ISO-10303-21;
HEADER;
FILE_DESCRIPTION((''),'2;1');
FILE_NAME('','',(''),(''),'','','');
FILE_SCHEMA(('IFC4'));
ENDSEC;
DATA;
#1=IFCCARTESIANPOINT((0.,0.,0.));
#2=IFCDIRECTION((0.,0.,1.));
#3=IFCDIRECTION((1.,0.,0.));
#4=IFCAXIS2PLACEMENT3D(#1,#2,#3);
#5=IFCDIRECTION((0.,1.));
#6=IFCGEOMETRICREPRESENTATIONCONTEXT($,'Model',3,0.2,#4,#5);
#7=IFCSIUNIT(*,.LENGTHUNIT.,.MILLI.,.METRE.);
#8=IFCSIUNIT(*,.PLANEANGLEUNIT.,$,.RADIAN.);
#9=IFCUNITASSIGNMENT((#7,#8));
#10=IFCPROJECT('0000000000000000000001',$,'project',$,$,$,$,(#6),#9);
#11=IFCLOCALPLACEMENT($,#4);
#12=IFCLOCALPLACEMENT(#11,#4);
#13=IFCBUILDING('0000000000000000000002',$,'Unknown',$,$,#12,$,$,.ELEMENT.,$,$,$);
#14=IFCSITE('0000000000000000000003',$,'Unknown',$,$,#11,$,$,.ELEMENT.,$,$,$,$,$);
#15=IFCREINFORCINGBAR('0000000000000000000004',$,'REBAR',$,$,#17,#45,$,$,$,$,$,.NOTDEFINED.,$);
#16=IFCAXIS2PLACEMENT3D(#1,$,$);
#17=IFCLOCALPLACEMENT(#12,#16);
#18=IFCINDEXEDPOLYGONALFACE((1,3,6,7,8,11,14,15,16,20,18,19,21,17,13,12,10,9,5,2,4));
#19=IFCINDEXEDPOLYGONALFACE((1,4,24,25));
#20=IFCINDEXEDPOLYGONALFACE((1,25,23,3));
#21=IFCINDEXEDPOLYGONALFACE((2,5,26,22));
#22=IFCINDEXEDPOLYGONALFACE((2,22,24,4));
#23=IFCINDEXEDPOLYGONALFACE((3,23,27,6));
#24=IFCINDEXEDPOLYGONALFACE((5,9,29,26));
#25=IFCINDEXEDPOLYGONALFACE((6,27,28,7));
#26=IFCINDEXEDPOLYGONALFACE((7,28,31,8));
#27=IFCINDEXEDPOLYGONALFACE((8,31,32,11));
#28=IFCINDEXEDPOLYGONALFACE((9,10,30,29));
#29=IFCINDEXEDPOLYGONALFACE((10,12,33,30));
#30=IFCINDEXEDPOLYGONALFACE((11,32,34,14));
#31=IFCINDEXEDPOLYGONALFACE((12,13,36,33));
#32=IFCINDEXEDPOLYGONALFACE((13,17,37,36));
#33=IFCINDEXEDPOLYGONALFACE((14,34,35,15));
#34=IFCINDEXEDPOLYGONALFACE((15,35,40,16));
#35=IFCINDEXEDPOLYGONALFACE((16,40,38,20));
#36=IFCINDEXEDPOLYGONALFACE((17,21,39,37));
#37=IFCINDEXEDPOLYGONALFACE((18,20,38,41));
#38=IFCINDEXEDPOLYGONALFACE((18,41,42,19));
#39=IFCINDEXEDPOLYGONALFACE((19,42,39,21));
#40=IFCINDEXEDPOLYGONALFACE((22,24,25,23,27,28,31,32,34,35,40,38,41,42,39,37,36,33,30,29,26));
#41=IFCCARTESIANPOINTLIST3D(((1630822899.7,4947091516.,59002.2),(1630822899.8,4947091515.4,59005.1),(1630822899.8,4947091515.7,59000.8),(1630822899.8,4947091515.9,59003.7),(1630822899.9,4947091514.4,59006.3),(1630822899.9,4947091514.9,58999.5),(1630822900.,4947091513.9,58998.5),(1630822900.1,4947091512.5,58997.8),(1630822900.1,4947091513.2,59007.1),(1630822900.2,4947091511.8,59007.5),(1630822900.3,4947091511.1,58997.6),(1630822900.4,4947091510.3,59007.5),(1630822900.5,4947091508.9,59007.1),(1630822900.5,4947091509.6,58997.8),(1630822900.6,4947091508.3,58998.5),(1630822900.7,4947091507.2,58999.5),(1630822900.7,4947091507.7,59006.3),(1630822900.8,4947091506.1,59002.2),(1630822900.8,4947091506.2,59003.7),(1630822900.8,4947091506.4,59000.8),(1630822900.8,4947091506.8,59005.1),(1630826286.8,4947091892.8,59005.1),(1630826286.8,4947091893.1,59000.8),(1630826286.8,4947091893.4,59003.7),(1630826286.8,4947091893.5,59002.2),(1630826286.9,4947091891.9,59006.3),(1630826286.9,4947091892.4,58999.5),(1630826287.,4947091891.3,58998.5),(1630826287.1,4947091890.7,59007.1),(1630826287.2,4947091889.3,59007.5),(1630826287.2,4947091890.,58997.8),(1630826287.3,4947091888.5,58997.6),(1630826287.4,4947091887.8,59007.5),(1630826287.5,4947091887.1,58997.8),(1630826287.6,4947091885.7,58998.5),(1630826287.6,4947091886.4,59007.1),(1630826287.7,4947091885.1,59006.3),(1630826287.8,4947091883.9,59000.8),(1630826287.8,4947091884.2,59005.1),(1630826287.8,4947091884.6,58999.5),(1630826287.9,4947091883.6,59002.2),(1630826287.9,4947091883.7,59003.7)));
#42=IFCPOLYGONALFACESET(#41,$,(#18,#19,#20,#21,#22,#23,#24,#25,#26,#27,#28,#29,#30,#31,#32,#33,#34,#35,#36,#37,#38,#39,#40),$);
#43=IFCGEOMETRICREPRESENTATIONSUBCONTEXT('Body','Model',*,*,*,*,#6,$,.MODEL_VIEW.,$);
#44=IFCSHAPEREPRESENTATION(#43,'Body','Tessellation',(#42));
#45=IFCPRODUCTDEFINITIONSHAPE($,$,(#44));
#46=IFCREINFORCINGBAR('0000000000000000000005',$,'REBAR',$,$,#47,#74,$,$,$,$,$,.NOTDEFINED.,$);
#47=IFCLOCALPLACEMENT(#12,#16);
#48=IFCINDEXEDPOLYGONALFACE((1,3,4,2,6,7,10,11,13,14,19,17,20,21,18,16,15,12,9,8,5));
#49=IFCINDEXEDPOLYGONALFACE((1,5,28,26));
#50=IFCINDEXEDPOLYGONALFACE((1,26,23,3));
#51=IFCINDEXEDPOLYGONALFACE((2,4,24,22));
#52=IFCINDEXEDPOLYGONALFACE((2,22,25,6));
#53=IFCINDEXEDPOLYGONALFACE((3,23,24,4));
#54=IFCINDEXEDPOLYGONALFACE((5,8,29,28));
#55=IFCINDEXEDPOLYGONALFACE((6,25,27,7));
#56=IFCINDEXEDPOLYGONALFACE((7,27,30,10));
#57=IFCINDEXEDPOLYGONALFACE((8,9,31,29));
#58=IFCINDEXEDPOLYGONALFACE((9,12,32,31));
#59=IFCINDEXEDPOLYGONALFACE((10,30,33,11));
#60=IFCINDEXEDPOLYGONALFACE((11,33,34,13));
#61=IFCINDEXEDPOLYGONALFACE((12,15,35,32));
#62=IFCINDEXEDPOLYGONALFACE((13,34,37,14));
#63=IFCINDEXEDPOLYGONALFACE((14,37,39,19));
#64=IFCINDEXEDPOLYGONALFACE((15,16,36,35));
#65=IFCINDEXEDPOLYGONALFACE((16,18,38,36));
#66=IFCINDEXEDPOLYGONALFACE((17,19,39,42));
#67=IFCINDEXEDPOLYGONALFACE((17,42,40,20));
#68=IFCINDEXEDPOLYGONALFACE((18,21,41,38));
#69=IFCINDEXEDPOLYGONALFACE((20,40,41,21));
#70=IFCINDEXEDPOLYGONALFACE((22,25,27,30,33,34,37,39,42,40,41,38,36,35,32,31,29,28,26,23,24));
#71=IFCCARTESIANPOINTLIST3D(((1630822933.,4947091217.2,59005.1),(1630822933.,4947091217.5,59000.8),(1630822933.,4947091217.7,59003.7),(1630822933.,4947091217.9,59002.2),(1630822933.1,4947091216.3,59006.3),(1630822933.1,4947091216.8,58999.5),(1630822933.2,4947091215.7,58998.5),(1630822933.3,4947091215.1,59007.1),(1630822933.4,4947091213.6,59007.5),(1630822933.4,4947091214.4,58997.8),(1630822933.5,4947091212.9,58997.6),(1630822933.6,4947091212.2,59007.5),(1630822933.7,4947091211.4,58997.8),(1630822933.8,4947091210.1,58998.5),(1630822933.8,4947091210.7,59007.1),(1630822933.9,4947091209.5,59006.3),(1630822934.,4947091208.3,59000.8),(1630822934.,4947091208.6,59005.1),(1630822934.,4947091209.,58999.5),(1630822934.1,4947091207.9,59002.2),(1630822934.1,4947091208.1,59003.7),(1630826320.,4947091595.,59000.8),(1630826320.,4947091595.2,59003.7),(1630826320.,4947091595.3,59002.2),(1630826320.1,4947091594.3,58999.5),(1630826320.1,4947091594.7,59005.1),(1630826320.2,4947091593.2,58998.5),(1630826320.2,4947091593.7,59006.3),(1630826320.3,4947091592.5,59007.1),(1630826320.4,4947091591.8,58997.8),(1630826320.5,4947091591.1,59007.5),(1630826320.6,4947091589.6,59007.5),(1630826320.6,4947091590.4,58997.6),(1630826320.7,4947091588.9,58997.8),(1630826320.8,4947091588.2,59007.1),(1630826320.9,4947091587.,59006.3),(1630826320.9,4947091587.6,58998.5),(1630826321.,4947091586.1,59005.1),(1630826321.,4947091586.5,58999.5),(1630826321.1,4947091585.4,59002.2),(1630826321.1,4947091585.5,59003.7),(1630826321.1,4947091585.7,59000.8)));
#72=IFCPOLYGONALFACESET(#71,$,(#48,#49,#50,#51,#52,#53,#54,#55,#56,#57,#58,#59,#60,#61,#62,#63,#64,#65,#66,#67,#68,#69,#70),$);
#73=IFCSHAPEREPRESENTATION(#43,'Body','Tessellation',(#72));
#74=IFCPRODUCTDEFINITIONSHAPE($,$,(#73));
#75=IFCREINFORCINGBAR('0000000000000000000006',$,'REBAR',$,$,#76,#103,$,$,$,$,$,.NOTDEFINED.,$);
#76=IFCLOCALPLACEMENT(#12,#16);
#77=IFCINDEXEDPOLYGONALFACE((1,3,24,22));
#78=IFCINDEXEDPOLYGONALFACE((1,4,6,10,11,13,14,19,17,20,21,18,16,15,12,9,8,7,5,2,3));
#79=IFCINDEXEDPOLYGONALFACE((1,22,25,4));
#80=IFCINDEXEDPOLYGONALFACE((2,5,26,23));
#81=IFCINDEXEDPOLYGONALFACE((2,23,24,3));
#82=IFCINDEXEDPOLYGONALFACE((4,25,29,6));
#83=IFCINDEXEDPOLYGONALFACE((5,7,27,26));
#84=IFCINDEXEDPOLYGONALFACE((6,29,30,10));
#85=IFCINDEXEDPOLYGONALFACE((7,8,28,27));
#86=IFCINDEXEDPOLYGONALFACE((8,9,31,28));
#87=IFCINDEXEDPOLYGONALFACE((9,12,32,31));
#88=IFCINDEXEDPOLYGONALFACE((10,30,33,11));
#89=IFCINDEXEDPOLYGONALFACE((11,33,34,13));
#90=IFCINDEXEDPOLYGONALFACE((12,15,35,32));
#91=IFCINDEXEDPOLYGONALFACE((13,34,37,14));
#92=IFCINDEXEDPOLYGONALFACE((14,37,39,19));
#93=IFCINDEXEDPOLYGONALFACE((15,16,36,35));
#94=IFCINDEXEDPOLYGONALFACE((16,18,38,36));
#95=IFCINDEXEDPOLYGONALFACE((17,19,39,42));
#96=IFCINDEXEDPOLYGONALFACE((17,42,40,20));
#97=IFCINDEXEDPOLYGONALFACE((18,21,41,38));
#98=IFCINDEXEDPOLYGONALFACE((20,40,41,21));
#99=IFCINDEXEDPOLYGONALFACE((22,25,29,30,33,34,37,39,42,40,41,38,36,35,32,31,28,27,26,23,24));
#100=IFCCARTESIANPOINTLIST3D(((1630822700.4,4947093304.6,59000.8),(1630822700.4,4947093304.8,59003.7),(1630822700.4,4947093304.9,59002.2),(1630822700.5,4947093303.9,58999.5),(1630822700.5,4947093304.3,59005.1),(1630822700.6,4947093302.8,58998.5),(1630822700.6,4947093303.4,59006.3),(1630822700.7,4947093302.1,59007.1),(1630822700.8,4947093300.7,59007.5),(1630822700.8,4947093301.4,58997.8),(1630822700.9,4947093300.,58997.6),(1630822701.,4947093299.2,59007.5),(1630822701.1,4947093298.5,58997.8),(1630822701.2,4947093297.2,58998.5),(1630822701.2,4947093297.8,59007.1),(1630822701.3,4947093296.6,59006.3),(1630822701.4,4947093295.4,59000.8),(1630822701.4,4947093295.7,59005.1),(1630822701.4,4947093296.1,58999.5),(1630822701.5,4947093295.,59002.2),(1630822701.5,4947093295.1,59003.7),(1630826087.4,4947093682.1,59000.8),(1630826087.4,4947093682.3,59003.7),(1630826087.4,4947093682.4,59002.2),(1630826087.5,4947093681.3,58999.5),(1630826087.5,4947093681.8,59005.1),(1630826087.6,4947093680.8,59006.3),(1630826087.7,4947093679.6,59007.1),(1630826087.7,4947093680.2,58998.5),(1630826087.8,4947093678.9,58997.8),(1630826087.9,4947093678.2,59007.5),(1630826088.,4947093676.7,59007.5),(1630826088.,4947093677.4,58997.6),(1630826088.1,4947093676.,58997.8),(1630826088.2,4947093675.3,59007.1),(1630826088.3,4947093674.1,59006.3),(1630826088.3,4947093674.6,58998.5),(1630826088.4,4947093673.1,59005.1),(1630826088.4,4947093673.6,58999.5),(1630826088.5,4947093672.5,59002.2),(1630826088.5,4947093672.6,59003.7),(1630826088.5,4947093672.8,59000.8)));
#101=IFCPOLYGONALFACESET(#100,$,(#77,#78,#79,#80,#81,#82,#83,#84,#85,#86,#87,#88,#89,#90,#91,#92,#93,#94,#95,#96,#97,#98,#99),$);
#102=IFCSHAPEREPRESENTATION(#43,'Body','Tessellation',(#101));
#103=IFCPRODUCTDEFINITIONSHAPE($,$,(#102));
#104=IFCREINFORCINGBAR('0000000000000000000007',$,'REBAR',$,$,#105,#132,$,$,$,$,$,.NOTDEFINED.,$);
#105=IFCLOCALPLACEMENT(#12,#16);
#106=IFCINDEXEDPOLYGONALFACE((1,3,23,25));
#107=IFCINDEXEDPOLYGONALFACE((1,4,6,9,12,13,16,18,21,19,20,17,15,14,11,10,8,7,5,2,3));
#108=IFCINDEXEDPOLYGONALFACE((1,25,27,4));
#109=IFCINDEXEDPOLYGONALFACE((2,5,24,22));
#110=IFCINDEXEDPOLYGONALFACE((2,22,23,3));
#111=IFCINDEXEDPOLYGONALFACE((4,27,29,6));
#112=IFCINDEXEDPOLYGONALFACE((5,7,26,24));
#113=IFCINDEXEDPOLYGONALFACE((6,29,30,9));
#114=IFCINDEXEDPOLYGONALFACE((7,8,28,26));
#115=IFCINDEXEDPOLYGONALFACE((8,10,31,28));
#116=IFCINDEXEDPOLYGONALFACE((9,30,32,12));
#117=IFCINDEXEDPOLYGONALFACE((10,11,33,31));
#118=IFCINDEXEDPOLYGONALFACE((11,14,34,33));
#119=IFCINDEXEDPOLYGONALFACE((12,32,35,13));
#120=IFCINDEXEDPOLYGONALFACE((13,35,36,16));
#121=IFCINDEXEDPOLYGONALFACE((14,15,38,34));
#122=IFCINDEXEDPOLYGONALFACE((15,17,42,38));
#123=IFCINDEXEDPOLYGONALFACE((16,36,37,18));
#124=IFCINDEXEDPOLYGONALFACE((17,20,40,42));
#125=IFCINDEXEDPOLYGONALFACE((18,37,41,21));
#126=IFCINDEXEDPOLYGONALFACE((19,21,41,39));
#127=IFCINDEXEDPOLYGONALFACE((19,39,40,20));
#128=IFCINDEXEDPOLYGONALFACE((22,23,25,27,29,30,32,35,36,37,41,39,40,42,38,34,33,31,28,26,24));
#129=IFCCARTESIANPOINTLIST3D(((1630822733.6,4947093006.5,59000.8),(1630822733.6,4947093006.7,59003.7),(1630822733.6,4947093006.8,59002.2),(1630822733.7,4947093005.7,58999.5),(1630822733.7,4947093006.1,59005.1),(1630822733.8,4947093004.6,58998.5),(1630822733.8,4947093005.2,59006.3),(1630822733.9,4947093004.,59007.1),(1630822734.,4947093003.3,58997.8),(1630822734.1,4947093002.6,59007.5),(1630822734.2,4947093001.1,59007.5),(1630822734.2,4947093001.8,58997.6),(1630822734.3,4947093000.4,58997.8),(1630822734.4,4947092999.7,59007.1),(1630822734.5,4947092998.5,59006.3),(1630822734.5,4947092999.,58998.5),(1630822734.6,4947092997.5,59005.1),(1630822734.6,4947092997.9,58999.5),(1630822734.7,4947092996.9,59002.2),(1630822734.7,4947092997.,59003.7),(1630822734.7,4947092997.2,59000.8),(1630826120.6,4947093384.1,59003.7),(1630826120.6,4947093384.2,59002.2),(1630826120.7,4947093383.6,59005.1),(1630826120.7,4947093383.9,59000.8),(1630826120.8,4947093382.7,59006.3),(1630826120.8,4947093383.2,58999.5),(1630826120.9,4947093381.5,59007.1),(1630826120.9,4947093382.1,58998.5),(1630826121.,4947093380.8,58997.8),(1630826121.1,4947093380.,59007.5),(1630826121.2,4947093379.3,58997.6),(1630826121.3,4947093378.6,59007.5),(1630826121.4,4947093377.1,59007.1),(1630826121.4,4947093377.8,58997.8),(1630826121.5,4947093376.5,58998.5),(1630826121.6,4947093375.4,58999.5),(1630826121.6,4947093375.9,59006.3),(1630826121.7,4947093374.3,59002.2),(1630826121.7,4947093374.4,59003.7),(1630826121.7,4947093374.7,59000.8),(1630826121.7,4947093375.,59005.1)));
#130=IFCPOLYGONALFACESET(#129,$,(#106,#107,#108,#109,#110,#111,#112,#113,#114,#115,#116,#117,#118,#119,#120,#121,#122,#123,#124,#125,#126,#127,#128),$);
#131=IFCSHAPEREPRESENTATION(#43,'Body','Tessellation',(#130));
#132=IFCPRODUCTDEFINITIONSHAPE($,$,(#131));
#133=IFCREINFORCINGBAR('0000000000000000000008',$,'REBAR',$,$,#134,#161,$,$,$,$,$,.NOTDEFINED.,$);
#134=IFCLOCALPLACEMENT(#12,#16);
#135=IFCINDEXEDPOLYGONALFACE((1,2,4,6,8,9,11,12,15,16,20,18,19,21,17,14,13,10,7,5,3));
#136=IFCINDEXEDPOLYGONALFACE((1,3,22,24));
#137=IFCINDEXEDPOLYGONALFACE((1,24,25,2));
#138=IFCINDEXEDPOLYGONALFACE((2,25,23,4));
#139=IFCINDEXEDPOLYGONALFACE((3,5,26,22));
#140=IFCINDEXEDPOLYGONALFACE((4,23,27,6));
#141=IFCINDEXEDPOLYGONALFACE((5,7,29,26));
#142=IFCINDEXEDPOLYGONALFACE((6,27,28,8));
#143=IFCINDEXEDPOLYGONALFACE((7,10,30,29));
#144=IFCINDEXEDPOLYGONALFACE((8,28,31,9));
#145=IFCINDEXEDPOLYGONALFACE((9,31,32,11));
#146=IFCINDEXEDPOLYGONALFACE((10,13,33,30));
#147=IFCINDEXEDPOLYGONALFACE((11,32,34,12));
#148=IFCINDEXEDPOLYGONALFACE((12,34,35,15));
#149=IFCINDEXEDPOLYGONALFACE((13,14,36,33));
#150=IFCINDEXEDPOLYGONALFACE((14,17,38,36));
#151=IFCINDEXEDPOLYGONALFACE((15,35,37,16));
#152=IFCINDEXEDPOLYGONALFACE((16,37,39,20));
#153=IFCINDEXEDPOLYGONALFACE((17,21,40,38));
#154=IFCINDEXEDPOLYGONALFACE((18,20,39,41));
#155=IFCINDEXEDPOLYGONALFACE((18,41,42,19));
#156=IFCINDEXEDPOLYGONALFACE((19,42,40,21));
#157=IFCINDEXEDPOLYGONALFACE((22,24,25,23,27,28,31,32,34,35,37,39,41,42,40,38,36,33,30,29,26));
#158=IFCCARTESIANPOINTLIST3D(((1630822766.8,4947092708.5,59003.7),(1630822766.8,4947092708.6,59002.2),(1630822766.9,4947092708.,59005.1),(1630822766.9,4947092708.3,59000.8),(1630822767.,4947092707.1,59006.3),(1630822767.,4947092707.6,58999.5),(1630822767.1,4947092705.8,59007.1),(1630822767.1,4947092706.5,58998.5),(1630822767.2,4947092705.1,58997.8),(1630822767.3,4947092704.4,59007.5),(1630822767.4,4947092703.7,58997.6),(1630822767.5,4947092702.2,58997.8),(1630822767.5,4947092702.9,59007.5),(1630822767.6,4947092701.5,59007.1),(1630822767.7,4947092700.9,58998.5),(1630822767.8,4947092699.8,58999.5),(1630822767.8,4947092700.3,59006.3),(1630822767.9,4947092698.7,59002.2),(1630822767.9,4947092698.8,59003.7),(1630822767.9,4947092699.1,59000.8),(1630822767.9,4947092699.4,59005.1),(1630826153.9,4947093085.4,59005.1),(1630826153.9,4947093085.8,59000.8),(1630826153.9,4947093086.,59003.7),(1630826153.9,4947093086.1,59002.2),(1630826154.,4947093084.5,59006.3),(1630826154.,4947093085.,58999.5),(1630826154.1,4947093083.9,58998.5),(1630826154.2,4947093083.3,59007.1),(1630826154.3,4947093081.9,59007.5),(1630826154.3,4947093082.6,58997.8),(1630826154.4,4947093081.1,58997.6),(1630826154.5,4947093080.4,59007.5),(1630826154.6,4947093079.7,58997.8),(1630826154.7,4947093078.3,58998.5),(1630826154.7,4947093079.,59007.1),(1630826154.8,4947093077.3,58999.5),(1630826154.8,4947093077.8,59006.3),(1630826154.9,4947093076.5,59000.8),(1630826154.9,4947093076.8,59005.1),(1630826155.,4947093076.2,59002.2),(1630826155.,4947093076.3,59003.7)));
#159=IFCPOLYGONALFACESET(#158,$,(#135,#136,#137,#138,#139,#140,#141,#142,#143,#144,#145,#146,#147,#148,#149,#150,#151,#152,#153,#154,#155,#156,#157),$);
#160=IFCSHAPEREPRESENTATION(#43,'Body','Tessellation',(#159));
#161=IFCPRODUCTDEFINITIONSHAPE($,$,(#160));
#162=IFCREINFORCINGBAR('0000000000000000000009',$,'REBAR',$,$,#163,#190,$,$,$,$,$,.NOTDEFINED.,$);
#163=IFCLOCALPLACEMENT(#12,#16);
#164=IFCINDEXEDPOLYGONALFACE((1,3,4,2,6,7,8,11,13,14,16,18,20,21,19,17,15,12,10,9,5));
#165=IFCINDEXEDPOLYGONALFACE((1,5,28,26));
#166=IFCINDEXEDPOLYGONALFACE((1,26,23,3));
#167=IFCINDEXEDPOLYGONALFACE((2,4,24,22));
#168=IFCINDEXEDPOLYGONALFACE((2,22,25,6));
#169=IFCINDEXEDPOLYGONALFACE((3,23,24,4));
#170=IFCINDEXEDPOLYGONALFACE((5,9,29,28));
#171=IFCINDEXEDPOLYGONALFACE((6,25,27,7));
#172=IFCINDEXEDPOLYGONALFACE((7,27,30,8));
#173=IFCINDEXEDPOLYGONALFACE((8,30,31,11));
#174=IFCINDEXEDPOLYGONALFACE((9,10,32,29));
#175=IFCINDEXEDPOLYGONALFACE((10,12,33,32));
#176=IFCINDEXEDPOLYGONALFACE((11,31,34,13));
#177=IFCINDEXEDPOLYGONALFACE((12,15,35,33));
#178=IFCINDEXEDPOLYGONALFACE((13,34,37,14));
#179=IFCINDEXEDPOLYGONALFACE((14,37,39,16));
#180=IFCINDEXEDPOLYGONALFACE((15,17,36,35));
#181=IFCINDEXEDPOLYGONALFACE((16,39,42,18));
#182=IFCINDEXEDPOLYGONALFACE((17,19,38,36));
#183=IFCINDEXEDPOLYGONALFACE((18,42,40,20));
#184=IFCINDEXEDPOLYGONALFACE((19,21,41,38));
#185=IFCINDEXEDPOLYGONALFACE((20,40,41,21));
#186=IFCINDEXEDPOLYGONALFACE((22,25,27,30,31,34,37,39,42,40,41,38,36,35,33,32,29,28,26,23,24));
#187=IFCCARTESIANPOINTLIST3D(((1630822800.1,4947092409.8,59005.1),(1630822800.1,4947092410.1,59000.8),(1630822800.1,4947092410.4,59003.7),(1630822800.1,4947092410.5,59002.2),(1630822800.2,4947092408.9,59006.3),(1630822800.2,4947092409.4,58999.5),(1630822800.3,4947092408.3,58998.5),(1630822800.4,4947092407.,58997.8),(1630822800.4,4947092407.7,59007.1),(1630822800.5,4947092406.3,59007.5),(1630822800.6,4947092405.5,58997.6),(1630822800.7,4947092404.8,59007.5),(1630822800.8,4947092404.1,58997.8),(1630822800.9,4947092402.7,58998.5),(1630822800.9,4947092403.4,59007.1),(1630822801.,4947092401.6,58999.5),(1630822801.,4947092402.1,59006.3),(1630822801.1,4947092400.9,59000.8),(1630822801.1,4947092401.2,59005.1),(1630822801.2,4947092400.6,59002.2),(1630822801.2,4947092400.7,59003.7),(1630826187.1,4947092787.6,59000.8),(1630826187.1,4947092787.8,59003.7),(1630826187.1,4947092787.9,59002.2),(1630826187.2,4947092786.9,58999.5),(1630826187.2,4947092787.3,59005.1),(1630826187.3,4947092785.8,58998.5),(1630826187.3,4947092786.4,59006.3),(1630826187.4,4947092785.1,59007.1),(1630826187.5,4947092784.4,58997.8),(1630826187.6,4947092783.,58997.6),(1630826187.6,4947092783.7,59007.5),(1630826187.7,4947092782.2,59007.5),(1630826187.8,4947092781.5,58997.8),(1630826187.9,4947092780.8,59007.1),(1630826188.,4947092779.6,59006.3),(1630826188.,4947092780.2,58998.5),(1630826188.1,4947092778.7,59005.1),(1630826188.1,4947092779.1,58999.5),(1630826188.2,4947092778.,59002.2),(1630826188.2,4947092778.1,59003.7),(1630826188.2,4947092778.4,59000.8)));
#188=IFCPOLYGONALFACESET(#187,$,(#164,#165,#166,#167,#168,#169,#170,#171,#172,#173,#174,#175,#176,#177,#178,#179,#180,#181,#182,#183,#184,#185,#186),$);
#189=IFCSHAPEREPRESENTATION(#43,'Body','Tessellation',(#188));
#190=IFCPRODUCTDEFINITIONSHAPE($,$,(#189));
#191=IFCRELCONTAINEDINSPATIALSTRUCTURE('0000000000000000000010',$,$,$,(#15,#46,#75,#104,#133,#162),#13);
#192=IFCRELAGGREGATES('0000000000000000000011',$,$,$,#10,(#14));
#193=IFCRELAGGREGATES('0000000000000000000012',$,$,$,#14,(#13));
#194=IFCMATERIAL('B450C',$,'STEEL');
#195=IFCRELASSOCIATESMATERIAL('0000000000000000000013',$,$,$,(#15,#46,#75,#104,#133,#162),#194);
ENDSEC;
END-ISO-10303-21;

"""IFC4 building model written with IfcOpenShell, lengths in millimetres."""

from ifc_helpers import new_model, entity, si_unit, direction, frame, origin_with_axes, place, context, subcontext, project, spatial, material, element, save


model = new_model("IFC4")

# Units and contexts
model_context = context("Model", 3, precision=0.2, world=origin_with_axes(), true_north=direction((0.0, 1.0)))
body_context = subcontext(model_context, "Body", "Model", "MODEL_VIEW")
ifc_project = project(units=[si_unit("LENGTHUNIT", "METRE", prefix="MILLI"), si_unit("PLANEANGLEUNIT", "RADIAN")], contexts=[model_context])

# Site, building
site_placement = place(None, origin_with_axes())
site = spatial("IfcSite", under=ifc_project, at=site_placement, Name="Unknown", CompositionType="ELEMENT")
building_placement = place(site_placement, origin_with_axes())
building = spatial("IfcBuilding", under=site, at=building_placement, Name="Unknown", CompositionType="ELEMENT")

# Reinforcing bars
ifc_material = material(Name="B450C", Category="STEEL")
for number, where, z_axis, x_axis, name in (
    (1, (1630826287.3, 4947091888.5, 59002.6), (0.000031, -0.000282, -1.0), (-0.993847, -0.110757, 0.0), "REBAR"),
    (2, (1630826320.6, 4947091590.4, 59002.6), (0.000031, -0.000282, -1.0), (-0.993847, -0.110757, 0.0), "REBAR"),
):
    element("IfcReinforcingBar", number, at=place(building_placement, frame(where, z_axis=z_axis, x_axis=x_axis)), inside=building, material=ifc_material, Name=name, PredefinedType="NOTDEFINED", context=body_context, shape_type="AdvancedSweptSolid", body=[
        entity("IfcSweptDiskSolid", entity("IfcIndexedPolyCurve", entity("IfcCartesianPointList3D", [[0.0, 0.0, 0.0], [3408.0, 0.0, 0.0]]), [entity("IfcLineIndex", [1, 2])]), 5.0),
    ])
reinforcing_bar_1_placement = place(building_placement, frame((1630826088.0, 4947093677.4, 59002.6), z_axis=(0.000031, -0.000282, -1.0), x_axis=(-0.993847, -0.110757, 0.0)))
element("IfcReinforcingBar", 3, at=reinforcing_bar_1_placement, inside=building, material=ifc_material, Name="REBAR", PredefinedType="NOTDEFINED", context=body_context, shape_type="AdvancedSweptSolid", body=[
    entity("IfcSweptDiskSolid", entity("IfcIndexedPolyCurve", entity("IfcCartesianPointList3D", [[0.0, 0.0, 0.0], [3408.0, 0.0, 0.0]]), [entity("IfcLineIndex", [1, 2])]), 5.0),
])
for number, where, z_axis, x_axis, name in (
    (4, (1630826121.2, 4947093379.3, 59002.6), (0.000031, -0.000282, -1.0), (-0.993847, -0.110757, 0.0), "REBAR"),
    (5, (1630826154.4, 4947093081.1, 59002.6), (0.000031, -0.000282, -1.0), (-0.993847, -0.110757, 0.0), "REBAR"),
    (6, (1630826187.6, 4947092783.0, 59002.6), (0.000031, -0.000282, -1.0), (-0.993847, -0.110757, 0.0), "REBAR"),
):
    element("IfcReinforcingBar", number, at=place(building_placement, frame(where, z_axis=z_axis, x_axis=x_axis)), inside=building, material=ifc_material, Name=name, PredefinedType="NOTDEFINED", context=body_context, shape_type="AdvancedSweptSolid", body=[
        entity("IfcSweptDiskSolid", entity("IfcIndexedPolyCurve", entity("IfcCartesianPointList3D", [[0.0, 0.0, 0.0], [3408.0, 0.0, 0.0]]), [entity("IfcLineIndex", [1, 2])]), 5.0),
    ])

save(model, "model.ifc")
